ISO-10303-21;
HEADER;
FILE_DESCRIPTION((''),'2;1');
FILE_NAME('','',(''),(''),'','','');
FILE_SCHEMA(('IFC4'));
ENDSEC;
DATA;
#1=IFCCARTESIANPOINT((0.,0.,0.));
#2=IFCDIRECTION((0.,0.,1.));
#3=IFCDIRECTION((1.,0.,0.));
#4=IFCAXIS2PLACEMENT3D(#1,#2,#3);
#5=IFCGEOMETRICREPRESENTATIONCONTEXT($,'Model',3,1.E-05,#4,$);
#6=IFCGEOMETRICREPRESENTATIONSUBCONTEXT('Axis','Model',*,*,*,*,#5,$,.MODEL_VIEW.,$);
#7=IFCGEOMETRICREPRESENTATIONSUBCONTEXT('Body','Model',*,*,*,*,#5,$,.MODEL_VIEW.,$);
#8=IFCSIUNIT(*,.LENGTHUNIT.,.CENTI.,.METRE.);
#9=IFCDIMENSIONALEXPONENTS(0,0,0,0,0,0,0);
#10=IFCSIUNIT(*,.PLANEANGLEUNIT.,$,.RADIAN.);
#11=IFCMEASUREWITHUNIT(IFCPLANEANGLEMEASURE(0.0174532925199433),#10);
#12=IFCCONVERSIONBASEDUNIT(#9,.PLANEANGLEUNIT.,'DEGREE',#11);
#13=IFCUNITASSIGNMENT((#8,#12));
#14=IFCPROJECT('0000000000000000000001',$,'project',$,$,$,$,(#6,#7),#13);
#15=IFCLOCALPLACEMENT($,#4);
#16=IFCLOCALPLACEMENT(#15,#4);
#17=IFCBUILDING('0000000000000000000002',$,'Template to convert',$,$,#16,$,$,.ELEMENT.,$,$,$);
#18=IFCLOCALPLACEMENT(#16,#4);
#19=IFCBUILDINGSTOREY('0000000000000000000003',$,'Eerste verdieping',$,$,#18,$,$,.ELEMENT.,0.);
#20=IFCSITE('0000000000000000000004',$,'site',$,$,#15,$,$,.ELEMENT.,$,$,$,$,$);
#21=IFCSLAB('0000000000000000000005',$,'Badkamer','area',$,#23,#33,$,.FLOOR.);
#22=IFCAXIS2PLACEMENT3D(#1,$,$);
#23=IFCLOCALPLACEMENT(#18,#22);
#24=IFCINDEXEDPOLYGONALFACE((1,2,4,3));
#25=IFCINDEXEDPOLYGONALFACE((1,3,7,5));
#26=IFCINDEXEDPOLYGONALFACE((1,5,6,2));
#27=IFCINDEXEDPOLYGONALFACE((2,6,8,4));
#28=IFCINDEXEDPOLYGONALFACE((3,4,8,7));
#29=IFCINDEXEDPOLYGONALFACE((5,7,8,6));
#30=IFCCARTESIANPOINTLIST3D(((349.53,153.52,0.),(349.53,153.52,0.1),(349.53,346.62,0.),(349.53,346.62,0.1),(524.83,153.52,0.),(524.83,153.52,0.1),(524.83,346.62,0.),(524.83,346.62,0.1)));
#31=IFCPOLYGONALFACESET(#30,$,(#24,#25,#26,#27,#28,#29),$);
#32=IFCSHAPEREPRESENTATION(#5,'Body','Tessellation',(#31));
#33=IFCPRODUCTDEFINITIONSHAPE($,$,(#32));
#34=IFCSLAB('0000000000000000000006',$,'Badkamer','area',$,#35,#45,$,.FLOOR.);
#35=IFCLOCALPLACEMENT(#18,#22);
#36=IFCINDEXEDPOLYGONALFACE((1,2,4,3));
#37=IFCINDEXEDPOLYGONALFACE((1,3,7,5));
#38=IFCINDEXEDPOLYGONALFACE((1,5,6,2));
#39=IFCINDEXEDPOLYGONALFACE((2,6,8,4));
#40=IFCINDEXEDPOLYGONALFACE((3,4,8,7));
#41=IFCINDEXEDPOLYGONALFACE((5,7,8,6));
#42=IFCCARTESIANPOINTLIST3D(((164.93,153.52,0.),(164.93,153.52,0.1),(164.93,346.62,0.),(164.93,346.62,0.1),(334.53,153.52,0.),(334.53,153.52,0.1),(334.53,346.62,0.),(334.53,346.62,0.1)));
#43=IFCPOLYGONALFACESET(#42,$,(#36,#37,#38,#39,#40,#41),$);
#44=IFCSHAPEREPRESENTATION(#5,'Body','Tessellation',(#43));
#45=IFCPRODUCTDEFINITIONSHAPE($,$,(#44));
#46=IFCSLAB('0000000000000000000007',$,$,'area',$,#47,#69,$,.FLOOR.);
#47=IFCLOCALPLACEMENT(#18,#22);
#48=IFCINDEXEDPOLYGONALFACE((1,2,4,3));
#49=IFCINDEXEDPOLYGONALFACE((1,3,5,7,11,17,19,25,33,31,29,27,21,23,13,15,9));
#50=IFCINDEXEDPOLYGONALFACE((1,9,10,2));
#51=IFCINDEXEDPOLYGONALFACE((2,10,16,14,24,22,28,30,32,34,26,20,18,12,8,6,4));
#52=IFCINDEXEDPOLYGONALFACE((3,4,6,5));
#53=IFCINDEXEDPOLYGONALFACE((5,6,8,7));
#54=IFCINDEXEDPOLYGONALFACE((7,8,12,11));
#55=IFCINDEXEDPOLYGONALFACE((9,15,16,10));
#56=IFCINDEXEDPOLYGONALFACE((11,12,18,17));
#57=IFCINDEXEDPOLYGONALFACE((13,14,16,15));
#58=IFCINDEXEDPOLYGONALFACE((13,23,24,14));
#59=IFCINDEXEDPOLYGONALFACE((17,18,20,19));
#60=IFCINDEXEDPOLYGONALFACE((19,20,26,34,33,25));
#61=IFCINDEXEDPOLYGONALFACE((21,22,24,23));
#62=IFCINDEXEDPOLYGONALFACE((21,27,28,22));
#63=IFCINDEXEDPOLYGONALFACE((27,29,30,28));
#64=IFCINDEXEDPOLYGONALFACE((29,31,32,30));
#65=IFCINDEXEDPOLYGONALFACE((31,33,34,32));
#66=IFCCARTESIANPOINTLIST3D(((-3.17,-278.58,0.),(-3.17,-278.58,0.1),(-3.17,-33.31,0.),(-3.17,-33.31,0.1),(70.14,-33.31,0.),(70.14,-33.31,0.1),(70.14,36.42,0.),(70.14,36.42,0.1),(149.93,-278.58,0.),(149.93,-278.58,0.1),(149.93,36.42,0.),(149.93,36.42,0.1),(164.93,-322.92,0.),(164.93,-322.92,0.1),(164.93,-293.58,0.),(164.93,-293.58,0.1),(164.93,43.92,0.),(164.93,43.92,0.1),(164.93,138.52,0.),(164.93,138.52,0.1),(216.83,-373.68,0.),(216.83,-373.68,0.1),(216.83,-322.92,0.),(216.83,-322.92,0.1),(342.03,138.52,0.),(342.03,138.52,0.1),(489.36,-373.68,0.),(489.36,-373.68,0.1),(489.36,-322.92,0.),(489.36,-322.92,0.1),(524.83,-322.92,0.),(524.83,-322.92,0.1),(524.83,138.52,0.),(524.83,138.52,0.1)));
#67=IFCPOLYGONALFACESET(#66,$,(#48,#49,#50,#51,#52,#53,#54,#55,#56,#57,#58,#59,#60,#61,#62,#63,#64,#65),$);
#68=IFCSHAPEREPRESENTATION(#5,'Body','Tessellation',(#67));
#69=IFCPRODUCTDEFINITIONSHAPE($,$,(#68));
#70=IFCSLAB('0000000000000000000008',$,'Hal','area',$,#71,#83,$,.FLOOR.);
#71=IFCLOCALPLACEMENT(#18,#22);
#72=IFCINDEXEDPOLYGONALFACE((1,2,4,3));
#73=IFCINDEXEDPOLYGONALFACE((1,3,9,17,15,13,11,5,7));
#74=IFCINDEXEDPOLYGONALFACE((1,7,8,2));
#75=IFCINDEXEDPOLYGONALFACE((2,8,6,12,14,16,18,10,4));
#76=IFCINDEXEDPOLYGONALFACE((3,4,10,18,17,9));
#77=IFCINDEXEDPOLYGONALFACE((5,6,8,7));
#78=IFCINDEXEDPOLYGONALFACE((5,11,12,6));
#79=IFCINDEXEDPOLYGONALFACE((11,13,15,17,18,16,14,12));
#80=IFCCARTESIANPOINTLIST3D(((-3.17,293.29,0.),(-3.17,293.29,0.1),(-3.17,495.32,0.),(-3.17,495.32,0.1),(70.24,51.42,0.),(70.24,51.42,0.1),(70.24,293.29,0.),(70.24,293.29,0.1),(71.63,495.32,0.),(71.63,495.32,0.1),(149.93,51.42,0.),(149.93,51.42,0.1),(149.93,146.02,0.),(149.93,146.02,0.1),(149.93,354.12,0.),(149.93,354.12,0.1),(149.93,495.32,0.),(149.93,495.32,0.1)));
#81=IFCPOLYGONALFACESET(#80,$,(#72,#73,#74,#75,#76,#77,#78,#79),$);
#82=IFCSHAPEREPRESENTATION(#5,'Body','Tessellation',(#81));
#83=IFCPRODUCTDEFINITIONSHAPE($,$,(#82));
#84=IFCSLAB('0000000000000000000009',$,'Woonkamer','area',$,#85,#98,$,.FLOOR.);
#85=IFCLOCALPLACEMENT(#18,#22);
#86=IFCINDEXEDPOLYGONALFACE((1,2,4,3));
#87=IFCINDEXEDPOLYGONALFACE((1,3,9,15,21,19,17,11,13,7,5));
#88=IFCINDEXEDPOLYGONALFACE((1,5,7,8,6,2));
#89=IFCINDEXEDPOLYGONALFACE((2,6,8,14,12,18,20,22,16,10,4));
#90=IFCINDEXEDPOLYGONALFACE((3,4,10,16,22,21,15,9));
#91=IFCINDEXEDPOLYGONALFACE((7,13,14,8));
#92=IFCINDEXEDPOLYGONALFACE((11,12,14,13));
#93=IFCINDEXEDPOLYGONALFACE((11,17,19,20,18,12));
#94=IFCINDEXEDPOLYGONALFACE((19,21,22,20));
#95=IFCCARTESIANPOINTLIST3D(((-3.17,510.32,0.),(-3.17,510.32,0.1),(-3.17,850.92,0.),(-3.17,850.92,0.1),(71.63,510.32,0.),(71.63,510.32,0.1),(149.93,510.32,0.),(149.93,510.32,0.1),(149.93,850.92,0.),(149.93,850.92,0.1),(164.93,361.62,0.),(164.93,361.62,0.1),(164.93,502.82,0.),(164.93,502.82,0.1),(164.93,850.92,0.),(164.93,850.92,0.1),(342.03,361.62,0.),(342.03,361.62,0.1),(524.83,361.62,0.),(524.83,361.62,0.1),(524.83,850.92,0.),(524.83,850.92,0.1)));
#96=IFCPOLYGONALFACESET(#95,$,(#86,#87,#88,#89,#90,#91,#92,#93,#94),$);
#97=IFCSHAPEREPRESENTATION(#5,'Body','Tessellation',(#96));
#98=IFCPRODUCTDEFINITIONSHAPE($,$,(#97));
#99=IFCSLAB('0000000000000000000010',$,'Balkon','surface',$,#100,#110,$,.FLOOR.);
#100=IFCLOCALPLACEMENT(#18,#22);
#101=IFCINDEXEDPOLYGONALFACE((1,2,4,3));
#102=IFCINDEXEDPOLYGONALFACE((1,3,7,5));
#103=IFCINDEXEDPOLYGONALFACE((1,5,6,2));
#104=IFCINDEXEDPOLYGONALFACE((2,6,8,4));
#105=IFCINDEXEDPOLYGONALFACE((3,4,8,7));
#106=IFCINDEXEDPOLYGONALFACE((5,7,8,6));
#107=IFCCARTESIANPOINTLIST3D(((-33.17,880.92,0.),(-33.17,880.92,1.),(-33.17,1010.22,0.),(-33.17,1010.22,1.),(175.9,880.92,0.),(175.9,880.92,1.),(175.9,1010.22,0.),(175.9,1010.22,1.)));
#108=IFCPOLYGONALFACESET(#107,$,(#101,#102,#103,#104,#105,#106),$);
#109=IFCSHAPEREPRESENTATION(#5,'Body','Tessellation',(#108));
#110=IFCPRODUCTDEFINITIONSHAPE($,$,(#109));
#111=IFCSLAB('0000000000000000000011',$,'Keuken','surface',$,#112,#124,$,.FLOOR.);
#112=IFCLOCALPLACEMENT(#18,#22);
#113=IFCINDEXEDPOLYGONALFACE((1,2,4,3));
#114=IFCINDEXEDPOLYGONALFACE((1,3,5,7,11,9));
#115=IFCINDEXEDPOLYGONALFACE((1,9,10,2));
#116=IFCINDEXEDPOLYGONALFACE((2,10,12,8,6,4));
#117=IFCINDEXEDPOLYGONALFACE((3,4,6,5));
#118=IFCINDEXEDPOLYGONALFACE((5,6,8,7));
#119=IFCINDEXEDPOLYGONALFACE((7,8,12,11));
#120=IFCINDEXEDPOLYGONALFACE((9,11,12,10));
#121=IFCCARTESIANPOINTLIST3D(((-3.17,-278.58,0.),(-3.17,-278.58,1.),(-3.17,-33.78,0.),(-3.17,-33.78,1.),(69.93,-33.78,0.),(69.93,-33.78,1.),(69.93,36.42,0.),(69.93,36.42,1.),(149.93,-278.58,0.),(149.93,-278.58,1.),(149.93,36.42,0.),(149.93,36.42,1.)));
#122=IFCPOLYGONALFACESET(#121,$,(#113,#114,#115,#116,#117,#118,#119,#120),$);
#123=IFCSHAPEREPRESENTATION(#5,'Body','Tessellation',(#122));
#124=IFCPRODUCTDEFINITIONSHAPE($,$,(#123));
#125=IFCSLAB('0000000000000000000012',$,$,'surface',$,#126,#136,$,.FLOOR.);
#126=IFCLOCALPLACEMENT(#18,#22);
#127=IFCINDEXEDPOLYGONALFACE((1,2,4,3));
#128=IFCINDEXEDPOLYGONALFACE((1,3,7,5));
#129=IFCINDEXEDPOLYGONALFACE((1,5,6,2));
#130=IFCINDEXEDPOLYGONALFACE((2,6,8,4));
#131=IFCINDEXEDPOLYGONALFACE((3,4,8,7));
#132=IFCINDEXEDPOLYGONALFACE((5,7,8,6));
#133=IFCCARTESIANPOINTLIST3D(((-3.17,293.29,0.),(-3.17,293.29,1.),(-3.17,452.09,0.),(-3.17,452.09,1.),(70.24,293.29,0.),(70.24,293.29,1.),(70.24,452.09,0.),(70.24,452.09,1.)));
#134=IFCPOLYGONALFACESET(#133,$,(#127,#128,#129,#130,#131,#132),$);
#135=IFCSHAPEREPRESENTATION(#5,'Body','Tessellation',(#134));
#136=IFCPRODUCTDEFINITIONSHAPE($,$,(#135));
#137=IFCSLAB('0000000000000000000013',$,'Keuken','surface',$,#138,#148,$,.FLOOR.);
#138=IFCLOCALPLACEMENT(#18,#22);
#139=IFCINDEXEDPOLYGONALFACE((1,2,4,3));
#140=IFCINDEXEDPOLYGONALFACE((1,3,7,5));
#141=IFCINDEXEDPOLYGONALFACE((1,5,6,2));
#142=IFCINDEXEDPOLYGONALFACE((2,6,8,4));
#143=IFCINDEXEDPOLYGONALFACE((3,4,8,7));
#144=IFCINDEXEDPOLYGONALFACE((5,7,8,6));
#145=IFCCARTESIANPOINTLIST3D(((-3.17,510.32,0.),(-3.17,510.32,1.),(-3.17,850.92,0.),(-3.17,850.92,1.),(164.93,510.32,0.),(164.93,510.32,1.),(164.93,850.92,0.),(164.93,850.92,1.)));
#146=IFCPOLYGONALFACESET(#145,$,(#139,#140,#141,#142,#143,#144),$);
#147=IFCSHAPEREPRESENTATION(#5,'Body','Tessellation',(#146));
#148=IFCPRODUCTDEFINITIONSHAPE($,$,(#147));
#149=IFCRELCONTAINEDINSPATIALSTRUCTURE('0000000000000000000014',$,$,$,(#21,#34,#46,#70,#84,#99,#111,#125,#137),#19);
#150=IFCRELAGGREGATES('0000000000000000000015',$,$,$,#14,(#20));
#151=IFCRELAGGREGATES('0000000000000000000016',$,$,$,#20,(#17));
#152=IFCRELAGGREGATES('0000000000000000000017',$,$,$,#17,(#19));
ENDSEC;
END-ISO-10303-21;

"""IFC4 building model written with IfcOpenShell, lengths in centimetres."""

from ifc_helpers import new_model, entity, si_unit, converted_unit, origin_with_axes, place, context, subcontext, project, spatial, polyline, outline, extrude, element, save


model = new_model("IFC4")

# Units and contexts
model_context = context("Model", 3, precision=1e-05, world=origin_with_axes())
body_context = subcontext(model_context, "Body", "Model", "MODEL_VIEW")
axis_context = subcontext(model_context, "Axis", "Model", "MODEL_VIEW")
ifc_project = project(units=[si_unit("LENGTHUNIT", "METRE", prefix="CENTI"), converted_unit("PLANEANGLEUNIT", "DEGREE", entity("IfcPlaneAngleMeasure", 0.0174532925199433), si_unit("PLANEANGLEUNIT", "RADIAN"), dimensions=[0, 0, 0, 0, 0, 0, 0])], contexts=[axis_context, body_context])

# Site, building, storey
site_placement = place(None, origin_with_axes())
site = spatial("IfcSite", under=ifc_project, at=site_placement, Name="site", CompositionType="ELEMENT")
building_placement = place(site_placement, origin_with_axes())
building = spatial("IfcBuilding", under=site, at=building_placement, Name="Template to convert", CompositionType="ELEMENT")
storey_placement = place(building_placement, origin_with_axes())
storey = spatial("IfcBuildingStorey", under=building, at=storey_placement, Name="Eerste verdieping", CompositionType="ELEMENT", Elevation=0.0)

# Slabs
slab_1_placement = place(storey_placement, origin_with_axes())
element("IfcSlab", 1, at=slab_1_placement, inside=storey, Name="Badkamer", Description="area", PredefinedType="FLOOR", context=model_context, shape_type="SweptSolid", body=[
    extrude(outline(polyline([(524.83, 153.52, 0.0), (524.83, 346.62, 0.0), (349.53, 346.62, 0.0), (349.53, 153.52, 0.0), (524.83, 153.52, 0.0), (524.83, 153.52, 0.0)])), origin_with_axes(), (0.0, 0.0, 1.0), 0.1),
])
slab_2_placement = place(storey_placement, origin_with_axes())
element("IfcSlab", 2, at=slab_2_placement, inside=storey, Name="Badkamer", Description="area", PredefinedType="FLOOR", context=model_context, shape_type="SweptSolid", body=[
    extrude(outline(polyline([(334.53, 153.52, 0.0), (334.53, 346.62, 0.0), (164.93, 346.62, 0.0), (164.93, 153.52, 0.0), (334.53, 153.52, 0.0), (334.53, 153.52, 0.0)])), origin_with_axes(), (0.0, 0.0, 1.0), 0.1),
])
slab_3_placement = place(storey_placement, origin_with_axes())
element("IfcSlab", 3, at=slab_3_placement, inside=storey, Description="area", PredefinedType="FLOOR", context=model_context, shape_type="SweptSolid", body=[
    extrude(outline(polyline([(-3.17, -278.58, 0.0), (149.93, -278.58, 0.0), (164.93, -293.58, 0.0), (164.93, -322.92, 0.0), (216.83, -322.92, 0.0), (216.83, -373.68, 0.0), (489.36, -373.68, 0.0), (489.36, -322.92, 0.0), (524.83, -322.92, 0.0), (524.83, 138.52, 0.0), (342.03, 138.52, 0.0), (164.93, 138.52, 0.0), (164.93, 43.92, 0.0), (149.93, 36.42, 0.0), (70.14, 36.42, 0.0), (70.14, -33.31, 0.0), (-3.17, -33.31, 0.0), (-3.17, -278.58, 0.0), (-3.17, -278.58, 0.0)])), origin_with_axes(), (0.0, 0.0, 1.0), 0.1),
])
slab_4_placement = place(storey_placement, origin_with_axes())
element("IfcSlab", 4, at=slab_4_placement, inside=storey, Name="Hal", Description="area", PredefinedType="FLOOR", context=model_context, shape_type="SweptSolid", body=[
    extrude(outline(polyline([(-3.17, 495.32, 0.0), (-3.17, 293.29, 0.0), (70.24, 293.29, 0.0), (70.24, 51.42, 0.0), (149.93, 51.42, 0.0), (149.93, 146.02, 0.0), (149.93, 354.12, 0.0), (149.93, 495.32, 0.0), (71.63, 495.32, 0.0), (-3.17, 495.32, 0.0), (-3.17, 495.32, 0.0)])), origin_with_axes(), (0.0, 0.0, 1.0), 0.1),
])
slab_5_placement = place(storey_placement, origin_with_axes())
element("IfcSlab", 5, at=slab_5_placement, inside=storey, Name="Woonkamer", Description="area", PredefinedType="FLOOR", context=model_context, shape_type="SweptSolid", body=[
    extrude(outline(polyline([(-3.17, 850.92, 0.0), (-3.17, 510.32, 0.0), (71.63, 510.32, 0.0), (149.93, 510.32, 0.0), (164.93, 502.82, 0.0), (164.93, 361.62, 0.0), (342.03, 361.62, 0.0), (524.83, 361.62, 0.0), (524.83, 850.92, 0.0), (164.93, 850.92, 0.0), (149.93, 850.92, 0.0), (-3.17, 850.92, 0.0), (-3.17, 850.92, 0.0)])), origin_with_axes(), (0.0, 0.0, 1.0), 0.1),
])
slab_6_placement = place(storey_placement, origin_with_axes())
element("IfcSlab", 6, at=slab_6_placement, inside=storey, Name="Balkon", Description="surface", PredefinedType="FLOOR", context=model_context, shape_type="SweptSolid", body=[
    extrude(outline(polyline([(-33.17, 880.92, 0.0), (-33.17, 1010.22, 0.0), (175.9, 1010.22, 0.0), (175.9, 880.92, 0.0), (-33.17, 880.92, 0.0), (-33.17, 880.92, 0.0)])), origin_with_axes(), (0.0, 0.0, 1.0), 1.0),
])
slab_7_placement = place(storey_placement, origin_with_axes())
element("IfcSlab", 7, at=slab_7_placement, inside=storey, Name="Keuken", Description="surface", PredefinedType="FLOOR", context=model_context, shape_type="SweptSolid", body=[
    extrude(outline(polyline([(-3.17, -278.58, 0.0), (-3.17, -33.78, 0.0), (69.93, -33.78, 0.0), (69.93, 36.42, 0.0), (149.93, 36.42, 0.0), (149.93, -278.58, 0.0), (-3.17, -278.58, 0.0), (-3.17, -278.58, 0.0)])), origin_with_axes(), (0.0, 0.0, 1.0), 1.0),
])
slab_8_placement = place(storey_placement, origin_with_axes())
element("IfcSlab", 8, at=slab_8_placement, inside=storey, Description="surface", PredefinedType="FLOOR", context=model_context, shape_type="SweptSolid", body=[
    extrude(outline(polyline([(-3.17, 293.29, 0.0), (70.24, 293.29, 0.0), (70.24, 452.09, 0.0), (-3.17, 452.09, 0.0), (-3.17, 293.29, 0.0), (-3.17, 293.29, 0.0)])), origin_with_axes(), (0.0, 0.0, 1.0), 1.0),
])
slab_9_placement = place(storey_placement, origin_with_axes())
element("IfcSlab", 9, at=slab_9_placement, inside=storey, Name="Keuken", Description="surface", PredefinedType="FLOOR", context=model_context, shape_type="SweptSolid", body=[
    extrude(outline(polyline([(-3.17, 510.32, 0.0), (-3.17, 850.92, 0.0), (164.93, 850.92, 0.0), (164.93, 510.32, 0.0), (-3.17, 510.32, 0.0), (-3.17, 510.32, 0.0)])), origin_with_axes(), (0.0, 0.0, 1.0), 1.0),
])

save(model, "model.ifc")
